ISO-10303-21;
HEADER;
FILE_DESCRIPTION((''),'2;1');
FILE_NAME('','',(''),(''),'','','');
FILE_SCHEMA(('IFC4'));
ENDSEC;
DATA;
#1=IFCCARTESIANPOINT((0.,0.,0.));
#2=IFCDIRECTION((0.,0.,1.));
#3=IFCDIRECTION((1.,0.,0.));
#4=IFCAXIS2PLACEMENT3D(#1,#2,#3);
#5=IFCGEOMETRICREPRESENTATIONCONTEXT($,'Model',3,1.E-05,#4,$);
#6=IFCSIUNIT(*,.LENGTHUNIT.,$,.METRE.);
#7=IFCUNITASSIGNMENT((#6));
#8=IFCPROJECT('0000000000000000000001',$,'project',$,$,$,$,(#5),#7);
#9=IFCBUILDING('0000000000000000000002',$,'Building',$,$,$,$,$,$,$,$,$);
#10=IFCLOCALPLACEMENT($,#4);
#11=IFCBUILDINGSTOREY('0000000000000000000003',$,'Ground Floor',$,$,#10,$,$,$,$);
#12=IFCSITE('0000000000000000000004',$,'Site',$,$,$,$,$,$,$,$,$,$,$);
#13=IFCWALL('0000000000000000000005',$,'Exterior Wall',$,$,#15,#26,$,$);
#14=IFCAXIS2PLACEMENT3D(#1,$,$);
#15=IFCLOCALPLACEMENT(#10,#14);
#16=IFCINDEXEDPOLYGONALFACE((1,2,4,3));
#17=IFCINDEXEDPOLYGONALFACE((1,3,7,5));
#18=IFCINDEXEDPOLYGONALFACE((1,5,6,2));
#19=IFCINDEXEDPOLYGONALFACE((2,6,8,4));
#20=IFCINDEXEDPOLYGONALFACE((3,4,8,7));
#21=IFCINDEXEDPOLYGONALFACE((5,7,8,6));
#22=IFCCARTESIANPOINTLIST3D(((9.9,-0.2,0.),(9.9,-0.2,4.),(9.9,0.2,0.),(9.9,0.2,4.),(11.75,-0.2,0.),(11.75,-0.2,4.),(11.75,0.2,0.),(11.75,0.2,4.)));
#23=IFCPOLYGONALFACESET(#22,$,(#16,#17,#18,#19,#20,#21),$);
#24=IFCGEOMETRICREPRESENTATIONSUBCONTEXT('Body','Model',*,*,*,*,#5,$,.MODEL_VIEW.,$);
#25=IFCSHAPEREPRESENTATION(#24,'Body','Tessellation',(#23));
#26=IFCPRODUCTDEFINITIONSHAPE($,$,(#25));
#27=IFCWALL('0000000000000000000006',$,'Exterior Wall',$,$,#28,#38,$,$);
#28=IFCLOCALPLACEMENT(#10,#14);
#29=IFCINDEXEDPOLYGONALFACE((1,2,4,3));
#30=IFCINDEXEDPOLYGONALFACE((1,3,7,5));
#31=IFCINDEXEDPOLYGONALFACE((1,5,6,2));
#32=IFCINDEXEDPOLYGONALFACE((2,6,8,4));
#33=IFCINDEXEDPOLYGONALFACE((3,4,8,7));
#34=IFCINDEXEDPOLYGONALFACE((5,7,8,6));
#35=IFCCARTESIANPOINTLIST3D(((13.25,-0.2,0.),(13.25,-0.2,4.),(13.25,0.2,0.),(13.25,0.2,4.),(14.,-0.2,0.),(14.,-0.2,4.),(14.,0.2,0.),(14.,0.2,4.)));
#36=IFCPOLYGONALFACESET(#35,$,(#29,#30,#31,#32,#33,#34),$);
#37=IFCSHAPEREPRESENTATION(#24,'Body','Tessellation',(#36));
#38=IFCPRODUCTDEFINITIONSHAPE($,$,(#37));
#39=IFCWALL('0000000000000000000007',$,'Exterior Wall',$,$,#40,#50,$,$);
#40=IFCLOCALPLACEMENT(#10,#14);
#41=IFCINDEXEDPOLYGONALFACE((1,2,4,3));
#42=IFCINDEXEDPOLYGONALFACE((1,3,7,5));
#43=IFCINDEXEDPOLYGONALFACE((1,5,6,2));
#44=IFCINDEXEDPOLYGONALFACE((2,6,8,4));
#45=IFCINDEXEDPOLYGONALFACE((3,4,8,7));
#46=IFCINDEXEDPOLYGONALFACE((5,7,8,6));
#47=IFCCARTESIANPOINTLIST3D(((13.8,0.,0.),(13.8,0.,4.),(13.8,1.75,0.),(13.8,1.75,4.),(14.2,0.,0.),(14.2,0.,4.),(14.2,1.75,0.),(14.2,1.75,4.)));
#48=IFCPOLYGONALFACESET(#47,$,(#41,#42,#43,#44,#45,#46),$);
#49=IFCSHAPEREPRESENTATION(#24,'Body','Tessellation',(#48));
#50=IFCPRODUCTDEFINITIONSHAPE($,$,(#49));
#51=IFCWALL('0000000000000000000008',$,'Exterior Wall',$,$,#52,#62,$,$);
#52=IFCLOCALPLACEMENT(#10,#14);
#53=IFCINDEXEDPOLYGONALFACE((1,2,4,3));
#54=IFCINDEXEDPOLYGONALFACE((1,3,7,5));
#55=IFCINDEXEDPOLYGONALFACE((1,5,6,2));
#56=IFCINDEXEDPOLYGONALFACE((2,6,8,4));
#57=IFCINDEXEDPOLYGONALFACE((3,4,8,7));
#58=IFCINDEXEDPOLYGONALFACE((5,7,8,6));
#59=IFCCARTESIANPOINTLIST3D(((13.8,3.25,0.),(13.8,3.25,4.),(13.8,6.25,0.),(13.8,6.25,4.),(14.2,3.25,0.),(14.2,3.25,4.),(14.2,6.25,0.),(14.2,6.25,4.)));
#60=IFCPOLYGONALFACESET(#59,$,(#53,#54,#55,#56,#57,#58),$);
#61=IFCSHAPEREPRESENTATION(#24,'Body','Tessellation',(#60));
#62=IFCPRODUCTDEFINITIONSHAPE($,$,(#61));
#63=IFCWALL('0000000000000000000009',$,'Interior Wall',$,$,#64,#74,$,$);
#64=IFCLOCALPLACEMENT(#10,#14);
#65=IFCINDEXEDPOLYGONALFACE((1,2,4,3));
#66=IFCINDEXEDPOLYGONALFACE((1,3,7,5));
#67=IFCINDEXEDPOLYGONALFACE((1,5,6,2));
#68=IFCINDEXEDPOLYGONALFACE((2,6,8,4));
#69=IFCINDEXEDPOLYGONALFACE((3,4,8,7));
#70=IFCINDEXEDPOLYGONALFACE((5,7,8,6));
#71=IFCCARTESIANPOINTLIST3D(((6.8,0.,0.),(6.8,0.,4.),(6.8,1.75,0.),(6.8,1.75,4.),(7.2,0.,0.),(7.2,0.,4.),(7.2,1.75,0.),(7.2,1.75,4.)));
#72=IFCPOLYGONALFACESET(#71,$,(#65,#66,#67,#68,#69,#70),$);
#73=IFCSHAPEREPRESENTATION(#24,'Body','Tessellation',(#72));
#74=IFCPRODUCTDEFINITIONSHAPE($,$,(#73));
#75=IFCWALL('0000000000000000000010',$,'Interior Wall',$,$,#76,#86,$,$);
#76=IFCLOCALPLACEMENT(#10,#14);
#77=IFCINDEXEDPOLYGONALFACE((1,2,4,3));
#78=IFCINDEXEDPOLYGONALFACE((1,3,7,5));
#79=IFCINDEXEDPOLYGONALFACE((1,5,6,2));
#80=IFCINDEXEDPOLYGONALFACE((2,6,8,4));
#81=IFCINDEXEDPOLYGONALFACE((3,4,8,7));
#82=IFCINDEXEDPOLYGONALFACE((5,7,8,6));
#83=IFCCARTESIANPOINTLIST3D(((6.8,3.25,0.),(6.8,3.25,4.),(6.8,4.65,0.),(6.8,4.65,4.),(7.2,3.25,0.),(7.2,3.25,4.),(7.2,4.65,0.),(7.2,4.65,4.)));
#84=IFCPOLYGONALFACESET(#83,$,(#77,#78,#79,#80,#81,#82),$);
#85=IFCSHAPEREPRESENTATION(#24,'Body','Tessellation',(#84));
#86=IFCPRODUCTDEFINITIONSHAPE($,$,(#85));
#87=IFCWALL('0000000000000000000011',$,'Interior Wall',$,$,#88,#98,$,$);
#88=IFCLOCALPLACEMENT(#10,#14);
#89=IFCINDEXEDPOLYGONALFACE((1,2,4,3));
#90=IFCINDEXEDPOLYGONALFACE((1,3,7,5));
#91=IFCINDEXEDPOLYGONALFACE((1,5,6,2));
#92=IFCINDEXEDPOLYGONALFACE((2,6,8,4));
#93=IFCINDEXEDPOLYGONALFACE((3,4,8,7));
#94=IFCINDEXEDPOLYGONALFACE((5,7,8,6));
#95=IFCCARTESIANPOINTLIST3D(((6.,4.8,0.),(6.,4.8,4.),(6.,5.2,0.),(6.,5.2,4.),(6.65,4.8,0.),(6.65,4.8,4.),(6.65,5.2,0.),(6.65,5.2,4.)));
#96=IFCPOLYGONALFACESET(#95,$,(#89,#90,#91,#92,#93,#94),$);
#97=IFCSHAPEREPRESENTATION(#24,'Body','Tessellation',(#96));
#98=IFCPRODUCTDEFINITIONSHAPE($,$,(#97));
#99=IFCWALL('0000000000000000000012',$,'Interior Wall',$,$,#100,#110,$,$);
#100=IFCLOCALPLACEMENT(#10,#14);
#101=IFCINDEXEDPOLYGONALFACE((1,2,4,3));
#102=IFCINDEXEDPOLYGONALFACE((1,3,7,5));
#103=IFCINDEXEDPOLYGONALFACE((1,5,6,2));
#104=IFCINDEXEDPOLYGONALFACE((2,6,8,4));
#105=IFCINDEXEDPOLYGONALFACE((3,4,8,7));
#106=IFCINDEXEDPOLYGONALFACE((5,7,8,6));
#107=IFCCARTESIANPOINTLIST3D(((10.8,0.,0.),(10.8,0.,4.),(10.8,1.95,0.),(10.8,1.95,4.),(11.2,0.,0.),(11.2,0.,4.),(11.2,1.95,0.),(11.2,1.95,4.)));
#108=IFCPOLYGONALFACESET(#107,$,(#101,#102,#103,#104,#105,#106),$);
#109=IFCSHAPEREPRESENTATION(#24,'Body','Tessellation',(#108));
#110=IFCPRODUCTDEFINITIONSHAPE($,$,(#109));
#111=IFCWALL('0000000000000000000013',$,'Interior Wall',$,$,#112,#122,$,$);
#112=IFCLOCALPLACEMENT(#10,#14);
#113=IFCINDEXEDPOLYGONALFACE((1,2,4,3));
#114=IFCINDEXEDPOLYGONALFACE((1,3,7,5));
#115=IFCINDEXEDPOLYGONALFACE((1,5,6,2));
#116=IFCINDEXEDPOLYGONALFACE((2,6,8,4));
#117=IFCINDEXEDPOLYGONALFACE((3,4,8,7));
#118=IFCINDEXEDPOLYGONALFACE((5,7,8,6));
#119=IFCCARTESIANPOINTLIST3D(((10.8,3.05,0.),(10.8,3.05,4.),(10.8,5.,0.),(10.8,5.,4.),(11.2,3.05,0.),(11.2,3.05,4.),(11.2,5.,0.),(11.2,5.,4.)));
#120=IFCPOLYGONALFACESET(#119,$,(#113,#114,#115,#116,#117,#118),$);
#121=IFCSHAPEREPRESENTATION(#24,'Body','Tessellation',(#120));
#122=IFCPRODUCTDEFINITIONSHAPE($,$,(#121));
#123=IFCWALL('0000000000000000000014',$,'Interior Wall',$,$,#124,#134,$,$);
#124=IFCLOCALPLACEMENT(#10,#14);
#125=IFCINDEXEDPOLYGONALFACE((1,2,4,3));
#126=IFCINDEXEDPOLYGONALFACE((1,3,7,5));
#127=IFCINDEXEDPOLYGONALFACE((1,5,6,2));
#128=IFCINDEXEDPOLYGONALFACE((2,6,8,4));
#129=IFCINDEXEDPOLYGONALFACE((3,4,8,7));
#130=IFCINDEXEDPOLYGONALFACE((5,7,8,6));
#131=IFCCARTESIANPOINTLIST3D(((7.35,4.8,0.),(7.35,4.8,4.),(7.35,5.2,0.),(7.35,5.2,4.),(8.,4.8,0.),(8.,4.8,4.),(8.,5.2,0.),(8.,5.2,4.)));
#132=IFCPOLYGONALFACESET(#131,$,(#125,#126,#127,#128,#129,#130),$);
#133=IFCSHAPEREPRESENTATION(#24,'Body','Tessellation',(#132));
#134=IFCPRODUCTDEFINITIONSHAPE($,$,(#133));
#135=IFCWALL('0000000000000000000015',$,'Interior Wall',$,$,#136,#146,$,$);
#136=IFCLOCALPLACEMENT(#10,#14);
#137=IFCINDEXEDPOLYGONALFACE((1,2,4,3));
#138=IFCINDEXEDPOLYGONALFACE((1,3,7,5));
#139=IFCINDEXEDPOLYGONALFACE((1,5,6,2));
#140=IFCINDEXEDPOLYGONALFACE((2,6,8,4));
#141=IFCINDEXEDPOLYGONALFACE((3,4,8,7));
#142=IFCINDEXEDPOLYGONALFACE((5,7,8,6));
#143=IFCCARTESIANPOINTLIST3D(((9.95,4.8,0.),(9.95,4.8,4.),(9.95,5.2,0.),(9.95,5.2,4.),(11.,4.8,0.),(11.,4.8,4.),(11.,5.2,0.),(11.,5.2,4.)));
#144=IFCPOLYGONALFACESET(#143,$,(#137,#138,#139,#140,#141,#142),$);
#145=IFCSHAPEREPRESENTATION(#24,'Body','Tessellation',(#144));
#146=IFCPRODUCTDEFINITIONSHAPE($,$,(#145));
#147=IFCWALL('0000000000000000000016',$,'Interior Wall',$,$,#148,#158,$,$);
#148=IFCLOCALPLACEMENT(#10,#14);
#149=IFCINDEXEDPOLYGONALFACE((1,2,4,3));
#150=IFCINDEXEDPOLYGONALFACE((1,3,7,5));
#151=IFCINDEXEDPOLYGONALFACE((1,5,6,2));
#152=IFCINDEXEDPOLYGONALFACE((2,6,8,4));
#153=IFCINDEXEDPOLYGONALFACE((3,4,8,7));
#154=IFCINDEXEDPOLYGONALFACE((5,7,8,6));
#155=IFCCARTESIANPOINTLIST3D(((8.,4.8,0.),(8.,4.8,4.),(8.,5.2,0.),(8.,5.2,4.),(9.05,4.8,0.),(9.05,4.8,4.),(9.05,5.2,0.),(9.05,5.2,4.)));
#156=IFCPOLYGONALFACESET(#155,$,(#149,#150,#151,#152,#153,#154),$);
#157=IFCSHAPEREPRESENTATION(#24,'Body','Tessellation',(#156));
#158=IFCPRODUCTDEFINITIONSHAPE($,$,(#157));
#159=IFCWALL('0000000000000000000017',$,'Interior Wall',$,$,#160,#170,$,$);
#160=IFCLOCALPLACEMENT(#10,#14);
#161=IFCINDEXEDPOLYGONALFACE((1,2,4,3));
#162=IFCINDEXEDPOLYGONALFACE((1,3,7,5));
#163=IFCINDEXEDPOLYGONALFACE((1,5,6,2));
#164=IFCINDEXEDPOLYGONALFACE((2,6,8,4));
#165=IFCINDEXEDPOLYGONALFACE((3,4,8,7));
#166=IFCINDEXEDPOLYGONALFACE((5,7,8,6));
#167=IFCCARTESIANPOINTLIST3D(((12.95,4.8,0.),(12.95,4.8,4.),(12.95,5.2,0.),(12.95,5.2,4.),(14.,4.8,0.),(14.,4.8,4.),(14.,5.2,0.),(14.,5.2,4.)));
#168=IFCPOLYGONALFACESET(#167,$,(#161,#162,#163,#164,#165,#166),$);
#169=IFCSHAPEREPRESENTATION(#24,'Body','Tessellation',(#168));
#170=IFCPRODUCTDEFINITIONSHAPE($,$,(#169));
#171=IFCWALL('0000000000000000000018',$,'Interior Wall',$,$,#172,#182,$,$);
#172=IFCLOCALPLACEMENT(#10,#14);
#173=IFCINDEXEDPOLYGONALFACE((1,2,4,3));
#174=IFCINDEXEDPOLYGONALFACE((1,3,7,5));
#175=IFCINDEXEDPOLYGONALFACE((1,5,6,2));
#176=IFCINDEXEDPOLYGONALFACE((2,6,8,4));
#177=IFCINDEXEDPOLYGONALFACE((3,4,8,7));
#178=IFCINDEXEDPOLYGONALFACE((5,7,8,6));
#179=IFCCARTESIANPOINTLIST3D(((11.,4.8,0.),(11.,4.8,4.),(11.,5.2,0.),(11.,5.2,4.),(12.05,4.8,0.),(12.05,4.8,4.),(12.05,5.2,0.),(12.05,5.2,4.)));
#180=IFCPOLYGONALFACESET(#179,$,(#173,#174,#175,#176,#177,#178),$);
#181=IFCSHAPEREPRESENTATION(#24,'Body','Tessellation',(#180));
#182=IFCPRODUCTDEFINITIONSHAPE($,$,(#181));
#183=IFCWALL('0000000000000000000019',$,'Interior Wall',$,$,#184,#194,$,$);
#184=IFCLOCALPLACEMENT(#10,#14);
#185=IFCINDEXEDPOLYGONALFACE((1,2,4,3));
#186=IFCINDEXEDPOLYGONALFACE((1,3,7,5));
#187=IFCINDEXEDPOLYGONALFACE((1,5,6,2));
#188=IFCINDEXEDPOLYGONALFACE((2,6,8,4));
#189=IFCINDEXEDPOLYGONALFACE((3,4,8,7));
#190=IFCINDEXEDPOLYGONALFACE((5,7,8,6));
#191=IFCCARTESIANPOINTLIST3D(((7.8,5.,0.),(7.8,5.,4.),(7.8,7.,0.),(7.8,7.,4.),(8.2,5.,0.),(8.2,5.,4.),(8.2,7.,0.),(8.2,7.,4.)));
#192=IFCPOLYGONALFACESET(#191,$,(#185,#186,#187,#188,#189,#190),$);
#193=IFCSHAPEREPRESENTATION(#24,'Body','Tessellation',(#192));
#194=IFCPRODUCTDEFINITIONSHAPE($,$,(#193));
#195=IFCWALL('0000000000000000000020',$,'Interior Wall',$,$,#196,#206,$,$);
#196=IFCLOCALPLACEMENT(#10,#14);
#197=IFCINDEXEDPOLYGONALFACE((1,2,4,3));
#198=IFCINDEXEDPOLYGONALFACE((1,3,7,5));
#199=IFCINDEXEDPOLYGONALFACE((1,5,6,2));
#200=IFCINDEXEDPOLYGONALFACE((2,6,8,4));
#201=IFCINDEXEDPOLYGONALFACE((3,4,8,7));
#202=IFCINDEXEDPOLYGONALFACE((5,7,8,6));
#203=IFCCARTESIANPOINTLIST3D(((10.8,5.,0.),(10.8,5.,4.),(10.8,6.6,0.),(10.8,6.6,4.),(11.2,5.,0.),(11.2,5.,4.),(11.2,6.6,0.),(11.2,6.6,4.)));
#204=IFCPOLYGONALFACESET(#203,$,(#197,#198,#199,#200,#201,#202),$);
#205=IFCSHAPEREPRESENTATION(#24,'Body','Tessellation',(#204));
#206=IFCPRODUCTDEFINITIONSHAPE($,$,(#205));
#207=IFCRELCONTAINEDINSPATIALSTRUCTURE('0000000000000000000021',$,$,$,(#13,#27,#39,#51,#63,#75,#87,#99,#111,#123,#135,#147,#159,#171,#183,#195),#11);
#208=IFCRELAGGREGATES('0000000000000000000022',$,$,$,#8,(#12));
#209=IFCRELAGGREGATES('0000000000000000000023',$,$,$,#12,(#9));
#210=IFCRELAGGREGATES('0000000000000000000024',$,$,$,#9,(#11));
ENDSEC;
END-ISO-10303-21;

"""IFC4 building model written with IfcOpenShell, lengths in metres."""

from ifc_helpers import new_model, si_unit, frame, origin_with_axes, place, context, subcontext, project, spatial, indexed_curve, outline, extrude, element, save


model = new_model("IFC4")

# Units and contexts
model_context = context("Model", 3, precision=1e-05, world=origin_with_axes())
body_context = subcontext(model_context, "Body", "Model", "MODEL_VIEW")
ifc_project = project(units=[si_unit("LENGTHUNIT", "METRE")], contexts=[model_context])

# Site, building, storey
site = spatial("IfcSite", under=ifc_project, Name="Site")
building = spatial("IfcBuilding", under=site, Name="Building")
storey_placement = place(None, origin_with_axes())
storey = spatial("IfcBuildingStorey", under=building, at=storey_placement, Name="Ground Floor")

# Walls
wall_1_placement = place(storey_placement, frame((9.9, 0.0, 0.0), z_axis=(0.0, 0.0, 1.0), x_axis=(1.0, 0.0, 0.0)))
element("IfcWall", 1, at=wall_1_placement, inside=storey, Name="Exterior Wall", context=body_context, shape_type="SweptSolid", body=[
    extrude(outline(indexed_curve([(0.0, 0.0), (0.0, 0.4), (1.85, 0.4), (1.85, 0.0), (0.0, 0.0)], self_intersect=False)), frame((0.0, -0.2, 0.0), z_axis=(0.0, 0.0, 1.0), x_axis=(1.0, 0.0, 0.0)), (0.0, 0.0, 1.0), 4.0),
])
wall_2_placement = place(storey_placement, frame((13.25, 0.0, 0.0), z_axis=(0.0, 0.0, 1.0), x_axis=(1.0, 0.0, 0.0)))
element("IfcWall", 2, at=wall_2_placement, inside=storey, Name="Exterior Wall", context=body_context, shape_type="SweptSolid", body=[
    extrude(outline(indexed_curve([(0.0, 0.0), (0.0, 0.4), (0.75, 0.4), (0.75, 0.0), (0.0, 0.0)], self_intersect=False)), frame((0.0, -0.2, 0.0), z_axis=(0.0, 0.0, 1.0), x_axis=(1.0, 0.0, 0.0)), (0.0, 0.0, 1.0), 4.0),
])
wall_3_placement = place(storey_placement, frame((14.0, 0.0, 0.0), z_axis=(0.0, 0.0, 1.0), x_axis=(0.0, 1.0, 0.0)))
element("IfcWall", 3, at=wall_3_placement, inside=storey, Name="Exterior Wall", context=body_context, shape_type="SweptSolid", body=[
    extrude(outline(indexed_curve([(0.0, 0.0), (0.0, 0.4), (1.75, 0.4), (1.75, 0.0), (0.0, 0.0)], self_intersect=False)), frame((0.0, -0.2, 0.0), z_axis=(0.0, 0.0, 1.0), x_axis=(1.0, 0.0, 0.0)), (0.0, 0.0, 1.0), 4.0),
])
wall_4_placement = place(storey_placement, frame((14.0, 3.25, 0.0), z_axis=(0.0, 0.0, 1.0), x_axis=(0.0, 1.0, 0.0)))
element("IfcWall", 4, at=wall_4_placement, inside=storey, Name="Exterior Wall", context=body_context, shape_type="SweptSolid", body=[
    extrude(outline(indexed_curve([(0.0, 0.0), (0.0, 0.4), (3.0, 0.4), (3.0, 0.0), (0.0, 0.0)], self_intersect=False)), frame((0.0, -0.2, 0.0), z_axis=(0.0, 0.0, 1.0), x_axis=(1.0, 0.0, 0.0)), (0.0, 0.0, 1.0), 4.0),
])
wall_5_placement = place(storey_placement, frame((7.0, 0.0, 0.0), z_axis=(0.0, 0.0, 1.0), x_axis=(0.0, 1.0, 0.0)))
element("IfcWall", 5, at=wall_5_placement, inside=storey, Name="Interior Wall", context=body_context, shape_type="SweptSolid", body=[
    extrude(outline(indexed_curve([(0.0, 0.0), (0.0, 0.4), (1.75, 0.4), (1.75, 0.0), (0.0, 0.0)], self_intersect=False)), frame((0.0, -0.2, 0.0), z_axis=(0.0, 0.0, 1.0), x_axis=(1.0, 0.0, 0.0)), (0.0, 0.0, 1.0), 4.0),
])
wall_6_placement = place(storey_placement, frame((7.0, 3.25, 0.0), z_axis=(0.0, 0.0, 1.0), x_axis=(0.0, 1.0, 0.0)))
element("IfcWall", 6, at=wall_6_placement, inside=storey, Name="Interior Wall", context=body_context, shape_type="SweptSolid", body=[
    extrude(outline(indexed_curve([(0.0, 0.0), (0.0, 0.4), (1.4, 0.4), (1.4, 0.0), (0.0, 0.0)], self_intersect=False)), frame((0.0, -0.2, 0.0), z_axis=(0.0, 0.0, 1.0), x_axis=(1.0, 0.0, 0.0)), (0.0, 0.0, 1.0), 4.0),
])
wall_7_placement = place(storey_placement, frame((6.65, 5.0, 0.0), z_axis=(0.0, 0.0, 1.0), x_axis=(-1.0, 0.0, 0.0)))
element("IfcWall", 7, at=wall_7_placement, inside=storey, Name="Interior Wall", context=body_context, shape_type="SweptSolid", body=[
    extrude(outline(indexed_curve([(0.0, 0.0), (0.0, 0.4), (0.65, 0.4), (0.65, 0.0), (0.0, 0.0)], self_intersect=False)), frame((0.0, -0.2, 0.0), z_axis=(0.0, 0.0, 1.0), x_axis=(1.0, 0.0, 0.0)), (0.0, 0.0, 1.0), 4.0),
])
wall_8_placement = place(storey_placement, frame((11.0, 0.0, 0.0), z_axis=(0.0, 0.0, 1.0), x_axis=(0.0, 1.0, 0.0)))
element("IfcWall", 8, at=wall_8_placement, inside=storey, Name="Interior Wall", context=body_context, shape_type="SweptSolid", body=[
    extrude(outline(indexed_curve([(0.0, 0.0), (0.0, 0.4), (1.95, 0.4), (1.95, 0.0), (0.0, 0.0)], self_intersect=False)), frame((0.0, -0.2, 0.0), z_axis=(0.0, 0.0, 1.0), x_axis=(1.0, 0.0, 0.0)), (0.0, 0.0, 1.0), 4.0),
])
wall_9_placement = place(storey_placement, frame((11.0, 3.05, 0.0), z_axis=(0.0, 0.0, 1.0), x_axis=(0.0, 1.0, 0.0)))
element("IfcWall", 9, at=wall_9_placement, inside=storey, Name="Interior Wall", context=body_context, shape_type="SweptSolid", body=[
    extrude(outline(indexed_curve([(0.0, 0.0), (0.0, 0.4), (1.95, 0.4), (1.95, 0.0), (0.0, 0.0)], self_intersect=False)), frame((0.0, -0.2, 0.0), z_axis=(0.0, 0.0, 1.0), x_axis=(1.0, 0.0, 0.0)), (0.0, 0.0, 1.0), 4.0),
])
wall_10_placement = place(storey_placement, frame((8.0, 5.0, 0.0), z_axis=(0.0, 0.0, 1.0), x_axis=(-1.0, 0.0, 0.0)))
element("IfcWall", 10, at=wall_10_placement, inside=storey, Name="Interior Wall", context=body_context, shape_type="SweptSolid", body=[
    extrude(outline(indexed_curve([(0.0, 0.0), (0.0, 0.4), (0.65, 0.4), (0.65, 0.0), (0.0, 0.0)], self_intersect=False)), frame((0.0, -0.2, 0.0), z_axis=(0.0, 0.0, 1.0), x_axis=(1.0, 0.0, 0.0)), (0.0, 0.0, 1.0), 4.0),
])
for number, where, z_axis, x_axis, name in (
    (11, (11.0, 5.0, 0.0), (0.0, 0.0, 1.0), (-1.0, 0.0, 0.0), "Interior Wall"),
    (12, (9.05, 5.0, 0.0), (0.0, 0.0, 1.0), (-1.0, 0.0, 0.0), "Interior Wall"),
    (13, (14.0, 5.0, 0.0), (0.0, 0.0, 1.0), (-1.0, 0.0, 0.0), "Interior Wall"),
    (14, (12.05, 5.0, 0.0), (0.0, 0.0, 1.0), (-1.0, 0.0, 0.0), "Interior Wall"),
):
    element("IfcWall", number, at=place(storey_placement, frame(where, z_axis=z_axis, x_axis=x_axis)), inside=storey, Name=name, context=body_context, shape_type="SweptSolid", body=[
        extrude(outline(indexed_curve([(0.0, 0.0), (0.0, 0.4), (1.05, 0.4), (1.05, 0.0), (0.0, 0.0)], self_intersect=False)), frame((0.0, -0.2, 0.0), z_axis=(0.0, 0.0, 1.0), x_axis=(1.0, 0.0, 0.0)), (0.0, 0.0, 1.0), 4.0),
    ])
wall_11_placement = place(storey_placement, frame((8.0, 5.0, 0.0), z_axis=(0.0, 0.0, 1.0), x_axis=(0.0, 1.0, 0.0)))
element("IfcWall", 15, at=wall_11_placement, inside=storey, Name="Interior Wall", context=body_context, shape_type="SweptSolid", body=[
    extrude(outline(indexed_curve([(0.0, 0.0), (0.0, 0.4), (2.0, 0.4), (2.0, 0.0), (0.0, 0.0)], self_intersect=False)), frame((0.0, -0.2, 0.0), z_axis=(0.0, 0.0, 1.0), x_axis=(1.0, 0.0, 0.0)), (0.0, 0.0, 1.0), 4.0),
])
wall_12_placement = place(storey_placement, frame((11.0, 5.0, 0.0), z_axis=(0.0, 0.0, 1.0), x_axis=(0.0, 1.0, 0.0)))
element("IfcWall", 16, at=wall_12_placement, inside=storey, Name="Interior Wall", context=body_context, shape_type="SweptSolid", body=[
    extrude(outline(indexed_curve([(0.0, 0.0), (0.0, 0.4), (1.6, 0.4), (1.6, 0.0), (0.0, 0.0)], self_intersect=False)), frame((0.0, -0.2, 0.0), z_axis=(0.0, 0.0, 1.0), x_axis=(1.0, 0.0, 0.0)), (0.0, 0.0, 1.0), 4.0),
])

save(model, "model.ifc")
